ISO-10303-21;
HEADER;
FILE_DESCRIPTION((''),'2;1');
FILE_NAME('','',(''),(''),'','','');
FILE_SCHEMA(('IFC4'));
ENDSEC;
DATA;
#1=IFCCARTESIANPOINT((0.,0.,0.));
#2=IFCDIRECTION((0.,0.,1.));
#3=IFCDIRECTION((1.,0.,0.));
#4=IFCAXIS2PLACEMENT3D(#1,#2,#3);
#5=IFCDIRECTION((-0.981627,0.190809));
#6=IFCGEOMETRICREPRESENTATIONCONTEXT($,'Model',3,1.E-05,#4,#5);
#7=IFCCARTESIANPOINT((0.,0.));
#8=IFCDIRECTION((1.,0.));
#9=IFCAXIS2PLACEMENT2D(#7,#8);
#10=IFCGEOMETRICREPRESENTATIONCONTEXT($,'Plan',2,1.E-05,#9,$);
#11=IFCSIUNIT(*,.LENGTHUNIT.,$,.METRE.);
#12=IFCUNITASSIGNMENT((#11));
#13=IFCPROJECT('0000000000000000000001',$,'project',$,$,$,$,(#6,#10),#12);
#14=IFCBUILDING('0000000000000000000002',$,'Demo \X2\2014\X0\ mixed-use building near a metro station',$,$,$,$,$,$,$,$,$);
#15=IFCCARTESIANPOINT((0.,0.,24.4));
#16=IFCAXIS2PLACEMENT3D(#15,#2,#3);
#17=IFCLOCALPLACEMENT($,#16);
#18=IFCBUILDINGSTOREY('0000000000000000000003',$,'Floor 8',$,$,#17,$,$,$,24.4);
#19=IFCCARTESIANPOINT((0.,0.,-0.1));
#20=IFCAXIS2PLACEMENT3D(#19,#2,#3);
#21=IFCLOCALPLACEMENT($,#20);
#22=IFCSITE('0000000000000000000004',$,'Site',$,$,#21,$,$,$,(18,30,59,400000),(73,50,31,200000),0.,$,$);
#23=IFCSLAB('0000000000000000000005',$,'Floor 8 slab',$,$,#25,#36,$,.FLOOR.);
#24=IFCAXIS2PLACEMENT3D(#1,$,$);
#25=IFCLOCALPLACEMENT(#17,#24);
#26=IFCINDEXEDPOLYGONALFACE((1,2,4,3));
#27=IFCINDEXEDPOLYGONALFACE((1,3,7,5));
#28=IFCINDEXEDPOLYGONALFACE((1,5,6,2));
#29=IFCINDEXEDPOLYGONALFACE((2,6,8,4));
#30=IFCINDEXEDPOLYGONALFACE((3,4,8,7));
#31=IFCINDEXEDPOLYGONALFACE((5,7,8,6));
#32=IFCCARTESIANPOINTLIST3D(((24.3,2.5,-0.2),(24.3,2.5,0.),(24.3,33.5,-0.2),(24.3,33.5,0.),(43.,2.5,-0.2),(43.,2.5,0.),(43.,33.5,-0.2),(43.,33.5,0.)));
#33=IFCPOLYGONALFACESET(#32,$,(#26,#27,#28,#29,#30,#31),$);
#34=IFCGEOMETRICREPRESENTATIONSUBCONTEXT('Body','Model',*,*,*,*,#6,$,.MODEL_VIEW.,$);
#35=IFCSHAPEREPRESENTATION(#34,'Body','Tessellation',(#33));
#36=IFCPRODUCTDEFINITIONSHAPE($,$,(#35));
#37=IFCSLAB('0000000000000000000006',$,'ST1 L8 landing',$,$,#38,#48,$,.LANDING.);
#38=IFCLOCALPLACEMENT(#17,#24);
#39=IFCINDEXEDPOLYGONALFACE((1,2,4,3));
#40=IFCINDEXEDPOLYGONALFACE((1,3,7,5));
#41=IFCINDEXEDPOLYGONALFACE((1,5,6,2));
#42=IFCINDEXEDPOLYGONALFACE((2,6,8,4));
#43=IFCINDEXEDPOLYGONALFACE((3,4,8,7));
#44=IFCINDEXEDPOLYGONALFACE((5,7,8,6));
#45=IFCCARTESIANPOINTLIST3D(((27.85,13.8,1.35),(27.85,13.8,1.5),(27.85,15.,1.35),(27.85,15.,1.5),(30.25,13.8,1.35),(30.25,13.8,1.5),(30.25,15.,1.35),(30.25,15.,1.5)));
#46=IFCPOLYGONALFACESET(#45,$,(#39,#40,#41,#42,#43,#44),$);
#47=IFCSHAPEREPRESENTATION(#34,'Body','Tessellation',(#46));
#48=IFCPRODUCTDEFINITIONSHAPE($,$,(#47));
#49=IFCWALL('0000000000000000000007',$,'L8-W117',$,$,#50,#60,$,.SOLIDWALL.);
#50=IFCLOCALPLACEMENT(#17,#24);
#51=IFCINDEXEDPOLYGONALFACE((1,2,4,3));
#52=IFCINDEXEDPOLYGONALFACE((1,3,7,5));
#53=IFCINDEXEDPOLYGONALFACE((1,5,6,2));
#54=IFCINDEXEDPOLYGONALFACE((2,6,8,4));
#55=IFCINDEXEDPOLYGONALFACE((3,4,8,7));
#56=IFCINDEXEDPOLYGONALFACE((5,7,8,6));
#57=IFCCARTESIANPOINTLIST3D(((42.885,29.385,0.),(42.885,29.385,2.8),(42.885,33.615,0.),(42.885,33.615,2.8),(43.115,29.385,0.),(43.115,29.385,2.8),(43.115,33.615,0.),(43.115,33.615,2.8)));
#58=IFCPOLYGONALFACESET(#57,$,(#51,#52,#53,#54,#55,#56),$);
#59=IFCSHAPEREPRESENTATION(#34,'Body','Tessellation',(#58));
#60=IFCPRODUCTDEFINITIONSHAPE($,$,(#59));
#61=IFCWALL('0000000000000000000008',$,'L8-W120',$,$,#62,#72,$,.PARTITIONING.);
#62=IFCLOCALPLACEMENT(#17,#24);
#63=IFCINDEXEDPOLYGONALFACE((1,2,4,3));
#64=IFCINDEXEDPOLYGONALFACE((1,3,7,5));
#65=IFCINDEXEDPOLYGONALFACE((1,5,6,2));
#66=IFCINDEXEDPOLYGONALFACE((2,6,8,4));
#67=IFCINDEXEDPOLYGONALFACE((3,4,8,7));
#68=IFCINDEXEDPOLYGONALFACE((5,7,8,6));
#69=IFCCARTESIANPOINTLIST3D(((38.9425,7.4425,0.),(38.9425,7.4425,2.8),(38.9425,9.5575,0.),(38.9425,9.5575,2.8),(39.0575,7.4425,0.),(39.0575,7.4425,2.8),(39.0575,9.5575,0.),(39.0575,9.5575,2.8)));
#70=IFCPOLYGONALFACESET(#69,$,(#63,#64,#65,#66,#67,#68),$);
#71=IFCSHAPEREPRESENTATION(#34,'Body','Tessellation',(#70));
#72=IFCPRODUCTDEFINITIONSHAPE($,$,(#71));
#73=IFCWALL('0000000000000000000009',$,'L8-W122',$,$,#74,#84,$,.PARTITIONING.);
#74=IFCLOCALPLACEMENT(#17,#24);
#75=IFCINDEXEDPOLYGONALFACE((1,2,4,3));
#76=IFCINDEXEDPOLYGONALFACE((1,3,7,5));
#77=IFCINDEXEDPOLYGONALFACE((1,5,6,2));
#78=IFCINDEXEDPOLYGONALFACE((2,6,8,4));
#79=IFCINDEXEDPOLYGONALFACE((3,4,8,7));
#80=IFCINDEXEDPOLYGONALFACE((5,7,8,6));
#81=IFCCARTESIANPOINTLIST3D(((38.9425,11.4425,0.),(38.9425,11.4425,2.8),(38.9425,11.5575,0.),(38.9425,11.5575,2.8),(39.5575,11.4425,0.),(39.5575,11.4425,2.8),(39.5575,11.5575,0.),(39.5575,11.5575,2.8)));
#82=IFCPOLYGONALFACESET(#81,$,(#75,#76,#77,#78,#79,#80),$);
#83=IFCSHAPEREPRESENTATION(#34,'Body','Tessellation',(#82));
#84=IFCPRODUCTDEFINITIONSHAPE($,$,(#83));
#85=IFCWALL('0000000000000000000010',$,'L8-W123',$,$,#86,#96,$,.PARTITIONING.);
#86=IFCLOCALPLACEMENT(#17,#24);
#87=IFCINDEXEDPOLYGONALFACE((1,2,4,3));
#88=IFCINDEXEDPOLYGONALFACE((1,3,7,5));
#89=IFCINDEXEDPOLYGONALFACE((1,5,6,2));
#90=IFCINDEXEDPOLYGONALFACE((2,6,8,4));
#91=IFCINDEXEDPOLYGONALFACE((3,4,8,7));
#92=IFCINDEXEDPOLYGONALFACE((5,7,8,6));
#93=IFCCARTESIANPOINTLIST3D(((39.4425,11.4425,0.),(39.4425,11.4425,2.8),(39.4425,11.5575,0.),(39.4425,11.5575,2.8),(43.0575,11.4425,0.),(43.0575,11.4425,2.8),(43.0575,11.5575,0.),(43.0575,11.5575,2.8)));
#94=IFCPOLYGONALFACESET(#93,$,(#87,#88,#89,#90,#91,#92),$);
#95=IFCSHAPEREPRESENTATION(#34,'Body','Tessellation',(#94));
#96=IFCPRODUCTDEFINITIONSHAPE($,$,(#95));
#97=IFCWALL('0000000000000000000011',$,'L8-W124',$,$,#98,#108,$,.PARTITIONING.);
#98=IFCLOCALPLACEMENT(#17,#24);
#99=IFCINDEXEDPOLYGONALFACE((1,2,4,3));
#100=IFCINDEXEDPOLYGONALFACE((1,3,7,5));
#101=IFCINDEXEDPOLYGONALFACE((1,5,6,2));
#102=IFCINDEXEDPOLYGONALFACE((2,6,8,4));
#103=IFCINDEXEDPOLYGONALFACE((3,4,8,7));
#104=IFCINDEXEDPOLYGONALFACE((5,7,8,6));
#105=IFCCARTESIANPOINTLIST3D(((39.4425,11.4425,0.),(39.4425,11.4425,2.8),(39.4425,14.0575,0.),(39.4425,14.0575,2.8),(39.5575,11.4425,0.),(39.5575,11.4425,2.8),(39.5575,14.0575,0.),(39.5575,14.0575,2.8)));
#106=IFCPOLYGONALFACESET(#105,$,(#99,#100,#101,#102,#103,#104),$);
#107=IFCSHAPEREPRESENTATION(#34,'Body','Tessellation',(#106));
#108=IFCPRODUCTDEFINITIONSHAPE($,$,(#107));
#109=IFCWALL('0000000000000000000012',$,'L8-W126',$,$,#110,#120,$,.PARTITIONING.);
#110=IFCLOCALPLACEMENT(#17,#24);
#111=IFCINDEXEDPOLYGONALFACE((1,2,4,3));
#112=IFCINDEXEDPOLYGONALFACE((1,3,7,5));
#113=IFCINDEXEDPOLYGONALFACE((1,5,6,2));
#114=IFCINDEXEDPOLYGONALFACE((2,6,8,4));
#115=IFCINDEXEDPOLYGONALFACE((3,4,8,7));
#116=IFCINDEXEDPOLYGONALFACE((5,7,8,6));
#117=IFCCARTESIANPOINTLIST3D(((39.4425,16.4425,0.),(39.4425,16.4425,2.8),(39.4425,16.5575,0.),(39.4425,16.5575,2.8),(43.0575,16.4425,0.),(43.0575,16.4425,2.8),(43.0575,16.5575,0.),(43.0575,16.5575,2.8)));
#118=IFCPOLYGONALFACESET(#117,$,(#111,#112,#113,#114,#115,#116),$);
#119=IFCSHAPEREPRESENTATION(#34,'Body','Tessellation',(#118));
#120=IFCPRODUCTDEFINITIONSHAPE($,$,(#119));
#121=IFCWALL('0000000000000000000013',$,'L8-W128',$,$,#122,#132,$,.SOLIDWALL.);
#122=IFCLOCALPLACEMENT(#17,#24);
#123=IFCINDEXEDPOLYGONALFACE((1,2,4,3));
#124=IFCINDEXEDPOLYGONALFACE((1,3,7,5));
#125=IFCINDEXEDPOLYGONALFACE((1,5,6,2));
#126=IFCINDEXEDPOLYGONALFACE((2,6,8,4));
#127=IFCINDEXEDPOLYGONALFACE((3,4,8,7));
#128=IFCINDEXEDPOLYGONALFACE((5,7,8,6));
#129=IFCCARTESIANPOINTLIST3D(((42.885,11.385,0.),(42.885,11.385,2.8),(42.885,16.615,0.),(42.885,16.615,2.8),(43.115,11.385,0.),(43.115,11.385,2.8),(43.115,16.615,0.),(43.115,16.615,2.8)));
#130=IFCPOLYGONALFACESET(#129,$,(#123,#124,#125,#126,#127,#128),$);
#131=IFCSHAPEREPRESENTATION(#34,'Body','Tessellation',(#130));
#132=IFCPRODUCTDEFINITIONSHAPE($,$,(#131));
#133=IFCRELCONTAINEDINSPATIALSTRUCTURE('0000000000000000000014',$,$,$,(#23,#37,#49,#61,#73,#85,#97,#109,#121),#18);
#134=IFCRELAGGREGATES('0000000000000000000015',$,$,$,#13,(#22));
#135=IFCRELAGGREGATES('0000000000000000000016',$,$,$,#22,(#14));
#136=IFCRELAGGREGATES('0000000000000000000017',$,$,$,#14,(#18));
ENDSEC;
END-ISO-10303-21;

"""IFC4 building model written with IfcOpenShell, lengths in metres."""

from ifc_helpers import new_model, si_unit, direction, frame, origin_with_axes, origin_2d_with_axis, place, context, subcontext, project, spatial, line, indexed_curve, outline, extrude, element, save


model = new_model("IFC4")

# Units and contexts
model_context = context("Model", 3, precision=1e-05, world=origin_with_axes(), true_north=direction((-0.981627, 0.190809)))
plan_context = context("Plan", 2, precision=1e-05, world=origin_2d_with_axis())
body_context = subcontext(model_context, "Body", "Model", "MODEL_VIEW")
ifc_project = project(units=[si_unit("LENGTHUNIT", "METRE")], contexts=[model_context, plan_context])

# Site, building, storey
site_placement = place(None, frame((0.0, 0.0, -0.1), z_axis=(0.0, 0.0, 1.0), x_axis=(1.0, 0.0, 0.0)))
site = spatial("IfcSite", under=ifc_project, at=site_placement, Name="Site", RefLatitude=(18, 30, 59, 400000), RefLongitude=(73, 50, 31, 200000), RefElevation=0.0)
building = spatial("IfcBuilding", under=site, Name="Demo — mixed-use building near a metro station")
storey_placement = place(None, frame((0.0, 0.0, 24.4), z_axis=(0.0, 0.0, 1.0), x_axis=(1.0, 0.0, 0.0)))
storey = spatial("IfcBuildingStorey", under=building, at=storey_placement, Name="Floor 8", Elevation=24.4)

# Slabs
slab_1_placement = place(storey_placement, frame((0.0, 0.0, -0.2), z_axis=(0.0, 0.0, 1.0), x_axis=(1.0, 0.0, 0.0)))
element("IfcSlab", 1, at=slab_1_placement, inside=storey, Name="Floor 8 slab", PredefinedType="FLOOR", context=body_context, shape_type="SweptSolid", body=[
    extrude(outline(indexed_curve([(24.3, 2.5), (43.0, 2.5), (43.0, 33.5), (24.3, 33.5)], segments=[line(1, 2, 3, 4, 1)])), origin_with_axes(), (0.0, 0.0, 1.0), 0.2),
])
slab_2_placement = place(storey_placement, frame((0.0, 0.0, -24.4), z_axis=(0.0, 0.0, 1.0), x_axis=(1.0, 0.0, 0.0)))
element("IfcSlab", 2, at=slab_2_placement, inside=storey, Name="ST1 L8 landing", PredefinedType="LANDING", context=body_context, shape_type="SweptSolid", body=[
    extrude(outline(indexed_curve([(27.85, 13.8), (30.25, 13.8), (30.25, 15.0), (27.85, 15.0)], segments=[line(1, 2, 3, 4, 1)])), frame((0.0, 0.0, 25.75), z_axis=(0.0, 0.0, 1.0), x_axis=(1.0, 0.0, 0.0)), (0.0, 0.0, 1.0), 0.15),
])

# Wall
wall_1_placement = place(storey_placement, frame((0.0, 0.0, -24.4), z_axis=(0.0, 0.0, 1.0), x_axis=(1.0, 0.0, 0.0)))
element("IfcWall", 3, at=wall_1_placement, inside=storey, Name="L8-W117", PredefinedType="SOLIDWALL", context=body_context, shape_type="SweptSolid", body=[
    extrude(outline(indexed_curve([(42.885, 29.385), (42.885, 33.615), (43.115, 33.615), (43.115, 29.385)], segments=[line(1, 2, 3, 4, 1)])), frame((0.0, 0.0, 24.4), z_axis=(0.0, 0.0, 1.0), x_axis=(1.0, 0.0, 0.0)), (0.0, 0.0, 1.0), 2.8),
])

# Wall
wall_2_placement = place(storey_placement, frame((0.0, 0.0, -24.4), z_axis=(0.0, 0.0, 1.0), x_axis=(1.0, 0.0, 0.0)))
element("IfcWall", 4, at=wall_2_placement, inside=storey, Name="L8-W120", PredefinedType="PARTITIONING", context=body_context, shape_type="SweptSolid", body=[
    extrude(outline(indexed_curve([(39.0575, 9.5575), (39.0575, 7.4425), (38.9425, 7.4425), (38.9425, 9.5575)], segments=[line(1, 2, 3, 4, 1)])), frame((0.0, 0.0, 24.4), z_axis=(0.0, 0.0, 1.0), x_axis=(1.0, 0.0, 0.0)), (0.0, 0.0, 1.0), 2.8),
])

# Walls
wall_3_placement = place(storey_placement, frame((0.0, 0.0, -24.4), z_axis=(0.0, 0.0, 1.0), x_axis=(1.0, 0.0, 0.0)))
element("IfcWall", 5, at=wall_3_placement, inside=storey, Name="L8-W122", PredefinedType="PARTITIONING", context=body_context, shape_type="SweptSolid", body=[
    extrude(outline(indexed_curve([(38.9425, 11.5575), (39.5575, 11.5575), (39.5575, 11.4425), (38.9425, 11.4425)], segments=[line(1, 2, 3, 4, 1)])), frame((0.0, 0.0, 24.4), z_axis=(0.0, 0.0, 1.0), x_axis=(1.0, 0.0, 0.0)), (0.0, 0.0, 1.0), 2.8),
])
wall_4_placement = place(storey_placement, frame((0.0, 0.0, -24.4), z_axis=(0.0, 0.0, 1.0), x_axis=(1.0, 0.0, 0.0)))
element("IfcWall", 6, at=wall_4_placement, inside=storey, Name="L8-W123", PredefinedType="PARTITIONING", context=body_context, shape_type="SweptSolid", body=[
    extrude(outline(indexed_curve([(39.4425, 11.5575), (43.0575, 11.5575), (43.0575, 11.4425), (39.4425, 11.4425)], segments=[line(1, 2, 3, 4, 1)])), frame((0.0, 0.0, 24.4), z_axis=(0.0, 0.0, 1.0), x_axis=(1.0, 0.0, 0.0)), (0.0, 0.0, 1.0), 2.8),
])
wall_5_placement = place(storey_placement, frame((0.0, 0.0, -24.4), z_axis=(0.0, 0.0, 1.0), x_axis=(1.0, 0.0, 0.0)))
element("IfcWall", 7, at=wall_5_placement, inside=storey, Name="L8-W124", PredefinedType="PARTITIONING", context=body_context, shape_type="SweptSolid", body=[
    extrude(outline(indexed_curve([(39.4425, 11.4425), (39.4425, 14.0575), (39.5575, 14.0575), (39.5575, 11.4425)], segments=[line(1, 2, 3, 4, 1)])), frame((0.0, 0.0, 24.4), z_axis=(0.0, 0.0, 1.0), x_axis=(1.0, 0.0, 0.0)), (0.0, 0.0, 1.0), 2.8),
])

# Wall
wall_6_placement = place(storey_placement, frame((0.0, 0.0, -24.4), z_axis=(0.0, 0.0, 1.0), x_axis=(1.0, 0.0, 0.0)))
element("IfcWall", 8, at=wall_6_placement, inside=storey, Name="L8-W126", PredefinedType="PARTITIONING", context=body_context, shape_type="SweptSolid", body=[
    extrude(outline(indexed_curve([(43.0575, 16.4425), (39.4425, 16.4425), (39.4425, 16.5575), (43.0575, 16.5575)], segments=[line(1, 2, 3, 4, 1)])), frame((0.0, 0.0, 24.4), z_axis=(0.0, 0.0, 1.0), x_axis=(1.0, 0.0, 0.0)), (0.0, 0.0, 1.0), 2.8),
])

# Wall
wall_7_placement = place(storey_placement, frame((0.0, 0.0, -24.4), z_axis=(0.0, 0.0, 1.0), x_axis=(1.0, 0.0, 0.0)))
element("IfcWall", 9, at=wall_7_placement, inside=storey, Name="L8-W128", PredefinedType="SOLIDWALL", context=body_context, shape_type="SweptSolid", body=[
    extrude(outline(indexed_curve([(42.885, 11.385), (42.885, 16.615), (43.115, 16.615), (43.115, 11.385)], segments=[line(1, 2, 3, 4, 1)])), frame((0.0, 0.0, 24.4), z_axis=(0.0, 0.0, 1.0), x_axis=(1.0, 0.0, 0.0)), (0.0, 0.0, 1.0), 2.8),
])

save(model, "model.ifc")
